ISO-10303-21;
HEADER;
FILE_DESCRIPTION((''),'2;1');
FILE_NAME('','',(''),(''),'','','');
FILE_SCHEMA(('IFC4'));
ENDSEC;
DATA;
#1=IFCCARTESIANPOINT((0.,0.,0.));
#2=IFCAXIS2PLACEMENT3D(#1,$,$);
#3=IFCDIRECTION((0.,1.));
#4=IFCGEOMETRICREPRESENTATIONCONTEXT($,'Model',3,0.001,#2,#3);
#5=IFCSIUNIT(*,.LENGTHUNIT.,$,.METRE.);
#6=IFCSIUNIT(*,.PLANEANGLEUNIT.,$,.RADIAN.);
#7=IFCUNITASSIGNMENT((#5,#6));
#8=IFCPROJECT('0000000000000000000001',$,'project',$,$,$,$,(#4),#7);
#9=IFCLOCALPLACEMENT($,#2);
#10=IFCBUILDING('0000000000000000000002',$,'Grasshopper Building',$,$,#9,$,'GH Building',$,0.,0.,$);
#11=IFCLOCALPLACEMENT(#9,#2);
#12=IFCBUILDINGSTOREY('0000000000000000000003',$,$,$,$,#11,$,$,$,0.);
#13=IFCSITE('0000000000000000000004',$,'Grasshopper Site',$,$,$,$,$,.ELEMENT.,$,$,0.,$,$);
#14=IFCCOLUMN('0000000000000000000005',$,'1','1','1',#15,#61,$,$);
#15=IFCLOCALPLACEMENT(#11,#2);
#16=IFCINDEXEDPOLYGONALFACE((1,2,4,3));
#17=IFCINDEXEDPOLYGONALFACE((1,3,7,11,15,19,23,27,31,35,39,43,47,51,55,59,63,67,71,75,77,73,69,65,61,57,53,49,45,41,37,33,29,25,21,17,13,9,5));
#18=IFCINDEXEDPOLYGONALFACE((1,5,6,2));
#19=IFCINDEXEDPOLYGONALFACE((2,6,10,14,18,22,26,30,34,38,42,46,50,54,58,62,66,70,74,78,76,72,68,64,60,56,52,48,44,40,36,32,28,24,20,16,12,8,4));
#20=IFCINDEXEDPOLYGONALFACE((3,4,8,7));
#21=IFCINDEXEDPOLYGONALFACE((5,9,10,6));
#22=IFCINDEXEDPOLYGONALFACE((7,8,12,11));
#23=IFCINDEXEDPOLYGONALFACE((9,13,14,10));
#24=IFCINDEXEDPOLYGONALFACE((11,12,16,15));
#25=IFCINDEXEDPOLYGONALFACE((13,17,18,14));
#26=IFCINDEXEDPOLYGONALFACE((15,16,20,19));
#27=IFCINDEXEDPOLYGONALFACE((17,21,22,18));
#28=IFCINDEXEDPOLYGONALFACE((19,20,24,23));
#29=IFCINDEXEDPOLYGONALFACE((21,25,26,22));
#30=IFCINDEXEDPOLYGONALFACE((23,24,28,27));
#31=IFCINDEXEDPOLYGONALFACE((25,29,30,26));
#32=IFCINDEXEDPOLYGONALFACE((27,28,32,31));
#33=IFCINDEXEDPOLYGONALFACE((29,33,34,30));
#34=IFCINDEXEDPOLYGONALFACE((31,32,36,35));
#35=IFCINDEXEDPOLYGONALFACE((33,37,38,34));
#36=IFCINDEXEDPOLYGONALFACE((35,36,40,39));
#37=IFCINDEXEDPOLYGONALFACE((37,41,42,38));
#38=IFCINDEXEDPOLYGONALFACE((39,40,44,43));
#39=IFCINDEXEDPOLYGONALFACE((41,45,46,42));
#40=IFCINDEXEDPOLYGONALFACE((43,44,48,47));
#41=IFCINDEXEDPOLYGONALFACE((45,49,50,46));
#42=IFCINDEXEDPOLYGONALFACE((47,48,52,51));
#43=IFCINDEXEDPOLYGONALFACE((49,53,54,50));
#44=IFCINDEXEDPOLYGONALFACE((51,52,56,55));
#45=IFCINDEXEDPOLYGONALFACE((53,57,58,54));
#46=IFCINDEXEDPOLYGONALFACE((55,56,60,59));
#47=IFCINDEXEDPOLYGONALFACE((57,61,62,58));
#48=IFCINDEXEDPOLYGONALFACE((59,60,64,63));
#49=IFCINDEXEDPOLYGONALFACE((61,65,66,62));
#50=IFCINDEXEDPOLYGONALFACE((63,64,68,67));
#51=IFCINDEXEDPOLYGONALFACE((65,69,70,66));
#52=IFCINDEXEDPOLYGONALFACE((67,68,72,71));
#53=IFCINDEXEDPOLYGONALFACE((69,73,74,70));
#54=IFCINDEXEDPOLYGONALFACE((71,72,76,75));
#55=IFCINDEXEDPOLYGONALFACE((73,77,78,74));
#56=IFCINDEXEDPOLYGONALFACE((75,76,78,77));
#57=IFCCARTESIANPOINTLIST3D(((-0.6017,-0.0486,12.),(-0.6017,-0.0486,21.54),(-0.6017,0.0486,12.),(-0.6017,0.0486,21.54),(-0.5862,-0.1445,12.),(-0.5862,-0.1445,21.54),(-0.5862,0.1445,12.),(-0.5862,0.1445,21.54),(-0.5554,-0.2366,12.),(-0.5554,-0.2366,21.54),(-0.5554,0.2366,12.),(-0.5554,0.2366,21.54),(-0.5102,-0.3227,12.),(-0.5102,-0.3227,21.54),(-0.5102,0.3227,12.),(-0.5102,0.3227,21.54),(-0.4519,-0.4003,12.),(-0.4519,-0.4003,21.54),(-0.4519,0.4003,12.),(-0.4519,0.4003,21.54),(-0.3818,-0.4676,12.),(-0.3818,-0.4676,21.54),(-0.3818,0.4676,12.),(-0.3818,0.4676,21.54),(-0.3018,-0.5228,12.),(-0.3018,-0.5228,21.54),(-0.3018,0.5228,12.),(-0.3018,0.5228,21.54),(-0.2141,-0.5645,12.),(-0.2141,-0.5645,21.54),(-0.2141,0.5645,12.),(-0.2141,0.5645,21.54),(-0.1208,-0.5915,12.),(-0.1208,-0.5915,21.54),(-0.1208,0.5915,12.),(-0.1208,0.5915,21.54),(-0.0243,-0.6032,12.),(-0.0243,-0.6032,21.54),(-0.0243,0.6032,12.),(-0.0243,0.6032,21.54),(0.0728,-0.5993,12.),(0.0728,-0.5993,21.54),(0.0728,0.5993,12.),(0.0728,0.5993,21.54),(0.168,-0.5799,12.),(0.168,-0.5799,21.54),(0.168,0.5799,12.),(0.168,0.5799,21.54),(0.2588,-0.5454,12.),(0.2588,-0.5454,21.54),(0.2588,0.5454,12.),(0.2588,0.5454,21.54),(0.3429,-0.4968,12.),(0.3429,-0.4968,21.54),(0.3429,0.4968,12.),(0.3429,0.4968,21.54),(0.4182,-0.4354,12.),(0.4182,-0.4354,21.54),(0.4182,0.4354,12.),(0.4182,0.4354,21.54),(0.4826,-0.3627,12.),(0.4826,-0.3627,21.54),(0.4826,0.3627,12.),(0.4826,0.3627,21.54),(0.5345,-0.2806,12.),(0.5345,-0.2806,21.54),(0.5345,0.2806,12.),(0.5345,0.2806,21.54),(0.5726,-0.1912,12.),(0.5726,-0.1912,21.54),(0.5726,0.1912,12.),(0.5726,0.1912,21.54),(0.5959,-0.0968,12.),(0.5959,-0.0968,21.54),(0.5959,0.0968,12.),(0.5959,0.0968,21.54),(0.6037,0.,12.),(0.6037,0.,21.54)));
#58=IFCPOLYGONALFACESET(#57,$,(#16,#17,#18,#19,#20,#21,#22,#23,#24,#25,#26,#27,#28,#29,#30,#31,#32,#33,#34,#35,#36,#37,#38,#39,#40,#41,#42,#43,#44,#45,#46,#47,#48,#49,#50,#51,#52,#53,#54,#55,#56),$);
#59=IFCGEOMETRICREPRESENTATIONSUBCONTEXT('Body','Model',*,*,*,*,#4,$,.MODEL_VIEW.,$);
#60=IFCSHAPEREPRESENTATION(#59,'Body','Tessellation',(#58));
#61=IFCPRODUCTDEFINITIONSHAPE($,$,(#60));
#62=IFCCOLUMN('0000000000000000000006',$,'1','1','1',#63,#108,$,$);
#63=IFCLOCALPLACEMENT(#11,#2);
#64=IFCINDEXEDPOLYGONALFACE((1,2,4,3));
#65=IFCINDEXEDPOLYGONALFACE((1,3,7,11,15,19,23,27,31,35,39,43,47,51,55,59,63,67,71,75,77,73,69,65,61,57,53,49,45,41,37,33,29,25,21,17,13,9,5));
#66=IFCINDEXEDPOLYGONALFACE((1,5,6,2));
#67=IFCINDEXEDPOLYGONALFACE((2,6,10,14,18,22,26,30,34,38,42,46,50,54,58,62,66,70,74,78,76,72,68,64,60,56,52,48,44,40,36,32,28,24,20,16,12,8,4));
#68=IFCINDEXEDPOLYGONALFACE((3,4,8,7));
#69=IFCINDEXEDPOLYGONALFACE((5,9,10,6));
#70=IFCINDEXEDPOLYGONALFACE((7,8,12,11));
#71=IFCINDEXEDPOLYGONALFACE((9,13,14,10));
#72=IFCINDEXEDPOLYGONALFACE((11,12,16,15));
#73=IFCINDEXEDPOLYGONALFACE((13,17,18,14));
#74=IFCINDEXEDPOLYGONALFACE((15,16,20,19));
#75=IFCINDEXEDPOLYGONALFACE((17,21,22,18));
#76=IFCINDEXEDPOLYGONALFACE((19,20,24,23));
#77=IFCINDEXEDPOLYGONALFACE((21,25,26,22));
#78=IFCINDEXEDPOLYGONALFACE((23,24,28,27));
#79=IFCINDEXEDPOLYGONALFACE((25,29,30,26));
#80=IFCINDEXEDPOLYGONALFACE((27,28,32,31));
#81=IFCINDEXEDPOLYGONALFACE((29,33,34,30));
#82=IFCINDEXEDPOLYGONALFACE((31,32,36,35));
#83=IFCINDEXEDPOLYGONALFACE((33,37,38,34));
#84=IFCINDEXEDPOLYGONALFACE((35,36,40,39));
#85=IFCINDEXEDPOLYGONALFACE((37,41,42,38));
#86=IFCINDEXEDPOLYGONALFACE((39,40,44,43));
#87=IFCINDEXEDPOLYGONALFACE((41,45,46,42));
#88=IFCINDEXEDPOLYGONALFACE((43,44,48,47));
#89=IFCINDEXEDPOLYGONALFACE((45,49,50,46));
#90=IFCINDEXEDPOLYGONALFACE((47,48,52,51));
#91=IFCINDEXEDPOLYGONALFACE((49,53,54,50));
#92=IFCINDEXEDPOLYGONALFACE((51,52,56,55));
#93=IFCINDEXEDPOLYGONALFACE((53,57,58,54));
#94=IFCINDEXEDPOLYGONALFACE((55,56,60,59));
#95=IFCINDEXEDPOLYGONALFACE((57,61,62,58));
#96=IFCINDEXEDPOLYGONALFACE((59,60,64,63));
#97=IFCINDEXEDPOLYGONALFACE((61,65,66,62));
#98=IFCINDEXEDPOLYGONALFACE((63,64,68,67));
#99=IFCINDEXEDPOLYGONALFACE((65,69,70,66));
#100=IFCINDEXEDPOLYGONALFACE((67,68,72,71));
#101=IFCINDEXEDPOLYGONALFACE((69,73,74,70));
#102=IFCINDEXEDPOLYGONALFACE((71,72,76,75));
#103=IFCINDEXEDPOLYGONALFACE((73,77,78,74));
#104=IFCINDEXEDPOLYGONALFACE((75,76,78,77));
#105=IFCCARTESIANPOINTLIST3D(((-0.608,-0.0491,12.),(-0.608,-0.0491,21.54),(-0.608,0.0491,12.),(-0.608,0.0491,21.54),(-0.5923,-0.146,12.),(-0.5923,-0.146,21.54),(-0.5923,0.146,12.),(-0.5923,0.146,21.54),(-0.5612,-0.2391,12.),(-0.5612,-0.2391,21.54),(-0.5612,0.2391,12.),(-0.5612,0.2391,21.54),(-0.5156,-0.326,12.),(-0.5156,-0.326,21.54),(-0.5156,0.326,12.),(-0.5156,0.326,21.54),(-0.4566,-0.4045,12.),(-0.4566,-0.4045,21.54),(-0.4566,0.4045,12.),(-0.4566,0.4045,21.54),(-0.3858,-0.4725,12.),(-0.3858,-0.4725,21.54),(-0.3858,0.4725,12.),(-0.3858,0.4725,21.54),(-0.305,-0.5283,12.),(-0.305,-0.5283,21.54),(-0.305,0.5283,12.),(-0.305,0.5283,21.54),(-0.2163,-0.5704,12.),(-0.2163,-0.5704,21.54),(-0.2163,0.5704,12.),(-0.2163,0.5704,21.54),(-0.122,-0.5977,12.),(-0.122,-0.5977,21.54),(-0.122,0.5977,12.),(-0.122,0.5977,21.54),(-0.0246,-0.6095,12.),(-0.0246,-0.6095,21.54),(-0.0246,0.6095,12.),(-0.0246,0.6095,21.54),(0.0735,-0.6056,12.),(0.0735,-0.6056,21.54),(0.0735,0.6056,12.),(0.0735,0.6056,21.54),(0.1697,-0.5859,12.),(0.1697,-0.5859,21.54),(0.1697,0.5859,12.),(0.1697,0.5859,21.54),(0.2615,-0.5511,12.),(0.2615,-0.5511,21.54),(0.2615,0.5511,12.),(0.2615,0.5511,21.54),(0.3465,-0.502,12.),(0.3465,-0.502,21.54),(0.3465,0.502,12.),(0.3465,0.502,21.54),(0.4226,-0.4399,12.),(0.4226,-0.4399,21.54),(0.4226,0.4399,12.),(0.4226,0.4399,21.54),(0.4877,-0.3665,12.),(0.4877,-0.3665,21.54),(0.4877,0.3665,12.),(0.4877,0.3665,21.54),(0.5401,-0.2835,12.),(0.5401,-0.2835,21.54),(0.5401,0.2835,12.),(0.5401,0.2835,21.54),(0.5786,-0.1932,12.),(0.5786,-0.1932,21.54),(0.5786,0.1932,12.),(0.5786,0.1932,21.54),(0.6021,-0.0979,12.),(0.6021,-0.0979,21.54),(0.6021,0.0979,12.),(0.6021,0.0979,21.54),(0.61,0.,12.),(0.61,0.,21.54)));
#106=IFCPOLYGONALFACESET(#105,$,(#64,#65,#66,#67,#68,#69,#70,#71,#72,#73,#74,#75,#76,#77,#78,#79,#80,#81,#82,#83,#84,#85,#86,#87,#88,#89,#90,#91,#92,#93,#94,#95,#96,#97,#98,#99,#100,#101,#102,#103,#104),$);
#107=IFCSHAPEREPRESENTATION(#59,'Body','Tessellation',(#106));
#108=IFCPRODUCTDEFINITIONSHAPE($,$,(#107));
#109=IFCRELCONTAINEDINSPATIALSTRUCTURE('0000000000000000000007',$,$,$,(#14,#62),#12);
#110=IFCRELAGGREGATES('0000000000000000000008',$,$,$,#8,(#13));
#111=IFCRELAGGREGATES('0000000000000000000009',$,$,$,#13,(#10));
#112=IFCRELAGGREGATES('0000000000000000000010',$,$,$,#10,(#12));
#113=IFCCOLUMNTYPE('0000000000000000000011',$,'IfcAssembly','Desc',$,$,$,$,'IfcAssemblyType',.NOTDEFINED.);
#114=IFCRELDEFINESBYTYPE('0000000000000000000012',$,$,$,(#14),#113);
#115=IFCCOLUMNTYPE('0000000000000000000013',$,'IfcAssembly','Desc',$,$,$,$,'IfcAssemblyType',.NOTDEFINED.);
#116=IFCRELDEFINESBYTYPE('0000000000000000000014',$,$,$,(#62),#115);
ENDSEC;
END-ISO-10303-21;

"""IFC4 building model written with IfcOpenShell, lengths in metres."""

from ifc_helpers import new_model, si_unit, direction, frame, origin, place, context, subcontext, project, spatial, circle, extrude, source, transform, mapped, type_object, type_shapes, element, save


model = new_model("IFC4")

# Units and contexts
model_context = context("Model", 3, precision=0.001, world=origin(), true_north=direction((0.0, 1.0)))
body_context = subcontext(model_context, "Body", "Model", "MODEL_VIEW")
ifc_project = project(units=[si_unit("LENGTHUNIT", "METRE"), si_unit("PLANEANGLEUNIT", "RADIAN")], contexts=[model_context])

# Site, building, storey
site = spatial("IfcSite", under=ifc_project, Name="Grasshopper Site", CompositionType="ELEMENT", RefElevation=0.0)
building_placement = place(None, origin())
building = spatial("IfcBuilding", under=site, at=building_placement, Name="Grasshopper Building", LongName="GH Building", ElevationOfRefHeight=0.0, ElevationOfTerrain=0.0)
storey_placement = place(building_placement, origin())
storey = spatial("IfcBuildingStorey", under=building, at=storey_placement, Elevation=0.0)

# Columns
column_type_1 = type_object("IfcColumnType", Name="IfcAssembly", Description="Desc", ElementType="IfcAssemblyType", PredefinedType="NOTDEFINED")
shared_shape_1 = source(origin(), body_context, "Body", "SweptSolid", [
    extrude(circle(Radius=0.6037), frame((0.0, 0.0, 12.0)), (0.0, 0.0, 1.0), 9.54),
])
type_shapes(column_type_1, [shared_shape_1])
column_1_placement = place(storey_placement, origin())
element("IfcColumn", 1, at=column_1_placement, inside=storey, type_object=column_type_1, Name="1", Description="1", ObjectType="1", context=body_context, shape_type="MappedRepresentation", body=[
    mapped(shared_shape_1, transform((0.0, 0.0, 0.0), scale=1.0)),
])
column_type_2 = type_object("IfcColumnType", Name="IfcAssembly", Description="Desc", ElementType="IfcAssemblyType", PredefinedType="NOTDEFINED")
shared_shape_2 = source(origin(), body_context, "Body", "SweptSolid", [
    extrude(circle(Radius=0.61), frame((0.0, 0.0, 12.0)), (0.0, 0.0, 1.0), 9.54),
])
type_shapes(column_type_2, [shared_shape_2])
column_2_placement = place(storey_placement, origin())
element("IfcColumn", 2, at=column_2_placement, inside=storey, type_object=column_type_2, Name="1", Description="1", ObjectType="1", context=body_context, shape_type="MappedRepresentation", body=[
    mapped(shared_shape_2, transform((0.0, 0.0, 0.0), scale=1.0)),
])

save(model, "model.ifc")
